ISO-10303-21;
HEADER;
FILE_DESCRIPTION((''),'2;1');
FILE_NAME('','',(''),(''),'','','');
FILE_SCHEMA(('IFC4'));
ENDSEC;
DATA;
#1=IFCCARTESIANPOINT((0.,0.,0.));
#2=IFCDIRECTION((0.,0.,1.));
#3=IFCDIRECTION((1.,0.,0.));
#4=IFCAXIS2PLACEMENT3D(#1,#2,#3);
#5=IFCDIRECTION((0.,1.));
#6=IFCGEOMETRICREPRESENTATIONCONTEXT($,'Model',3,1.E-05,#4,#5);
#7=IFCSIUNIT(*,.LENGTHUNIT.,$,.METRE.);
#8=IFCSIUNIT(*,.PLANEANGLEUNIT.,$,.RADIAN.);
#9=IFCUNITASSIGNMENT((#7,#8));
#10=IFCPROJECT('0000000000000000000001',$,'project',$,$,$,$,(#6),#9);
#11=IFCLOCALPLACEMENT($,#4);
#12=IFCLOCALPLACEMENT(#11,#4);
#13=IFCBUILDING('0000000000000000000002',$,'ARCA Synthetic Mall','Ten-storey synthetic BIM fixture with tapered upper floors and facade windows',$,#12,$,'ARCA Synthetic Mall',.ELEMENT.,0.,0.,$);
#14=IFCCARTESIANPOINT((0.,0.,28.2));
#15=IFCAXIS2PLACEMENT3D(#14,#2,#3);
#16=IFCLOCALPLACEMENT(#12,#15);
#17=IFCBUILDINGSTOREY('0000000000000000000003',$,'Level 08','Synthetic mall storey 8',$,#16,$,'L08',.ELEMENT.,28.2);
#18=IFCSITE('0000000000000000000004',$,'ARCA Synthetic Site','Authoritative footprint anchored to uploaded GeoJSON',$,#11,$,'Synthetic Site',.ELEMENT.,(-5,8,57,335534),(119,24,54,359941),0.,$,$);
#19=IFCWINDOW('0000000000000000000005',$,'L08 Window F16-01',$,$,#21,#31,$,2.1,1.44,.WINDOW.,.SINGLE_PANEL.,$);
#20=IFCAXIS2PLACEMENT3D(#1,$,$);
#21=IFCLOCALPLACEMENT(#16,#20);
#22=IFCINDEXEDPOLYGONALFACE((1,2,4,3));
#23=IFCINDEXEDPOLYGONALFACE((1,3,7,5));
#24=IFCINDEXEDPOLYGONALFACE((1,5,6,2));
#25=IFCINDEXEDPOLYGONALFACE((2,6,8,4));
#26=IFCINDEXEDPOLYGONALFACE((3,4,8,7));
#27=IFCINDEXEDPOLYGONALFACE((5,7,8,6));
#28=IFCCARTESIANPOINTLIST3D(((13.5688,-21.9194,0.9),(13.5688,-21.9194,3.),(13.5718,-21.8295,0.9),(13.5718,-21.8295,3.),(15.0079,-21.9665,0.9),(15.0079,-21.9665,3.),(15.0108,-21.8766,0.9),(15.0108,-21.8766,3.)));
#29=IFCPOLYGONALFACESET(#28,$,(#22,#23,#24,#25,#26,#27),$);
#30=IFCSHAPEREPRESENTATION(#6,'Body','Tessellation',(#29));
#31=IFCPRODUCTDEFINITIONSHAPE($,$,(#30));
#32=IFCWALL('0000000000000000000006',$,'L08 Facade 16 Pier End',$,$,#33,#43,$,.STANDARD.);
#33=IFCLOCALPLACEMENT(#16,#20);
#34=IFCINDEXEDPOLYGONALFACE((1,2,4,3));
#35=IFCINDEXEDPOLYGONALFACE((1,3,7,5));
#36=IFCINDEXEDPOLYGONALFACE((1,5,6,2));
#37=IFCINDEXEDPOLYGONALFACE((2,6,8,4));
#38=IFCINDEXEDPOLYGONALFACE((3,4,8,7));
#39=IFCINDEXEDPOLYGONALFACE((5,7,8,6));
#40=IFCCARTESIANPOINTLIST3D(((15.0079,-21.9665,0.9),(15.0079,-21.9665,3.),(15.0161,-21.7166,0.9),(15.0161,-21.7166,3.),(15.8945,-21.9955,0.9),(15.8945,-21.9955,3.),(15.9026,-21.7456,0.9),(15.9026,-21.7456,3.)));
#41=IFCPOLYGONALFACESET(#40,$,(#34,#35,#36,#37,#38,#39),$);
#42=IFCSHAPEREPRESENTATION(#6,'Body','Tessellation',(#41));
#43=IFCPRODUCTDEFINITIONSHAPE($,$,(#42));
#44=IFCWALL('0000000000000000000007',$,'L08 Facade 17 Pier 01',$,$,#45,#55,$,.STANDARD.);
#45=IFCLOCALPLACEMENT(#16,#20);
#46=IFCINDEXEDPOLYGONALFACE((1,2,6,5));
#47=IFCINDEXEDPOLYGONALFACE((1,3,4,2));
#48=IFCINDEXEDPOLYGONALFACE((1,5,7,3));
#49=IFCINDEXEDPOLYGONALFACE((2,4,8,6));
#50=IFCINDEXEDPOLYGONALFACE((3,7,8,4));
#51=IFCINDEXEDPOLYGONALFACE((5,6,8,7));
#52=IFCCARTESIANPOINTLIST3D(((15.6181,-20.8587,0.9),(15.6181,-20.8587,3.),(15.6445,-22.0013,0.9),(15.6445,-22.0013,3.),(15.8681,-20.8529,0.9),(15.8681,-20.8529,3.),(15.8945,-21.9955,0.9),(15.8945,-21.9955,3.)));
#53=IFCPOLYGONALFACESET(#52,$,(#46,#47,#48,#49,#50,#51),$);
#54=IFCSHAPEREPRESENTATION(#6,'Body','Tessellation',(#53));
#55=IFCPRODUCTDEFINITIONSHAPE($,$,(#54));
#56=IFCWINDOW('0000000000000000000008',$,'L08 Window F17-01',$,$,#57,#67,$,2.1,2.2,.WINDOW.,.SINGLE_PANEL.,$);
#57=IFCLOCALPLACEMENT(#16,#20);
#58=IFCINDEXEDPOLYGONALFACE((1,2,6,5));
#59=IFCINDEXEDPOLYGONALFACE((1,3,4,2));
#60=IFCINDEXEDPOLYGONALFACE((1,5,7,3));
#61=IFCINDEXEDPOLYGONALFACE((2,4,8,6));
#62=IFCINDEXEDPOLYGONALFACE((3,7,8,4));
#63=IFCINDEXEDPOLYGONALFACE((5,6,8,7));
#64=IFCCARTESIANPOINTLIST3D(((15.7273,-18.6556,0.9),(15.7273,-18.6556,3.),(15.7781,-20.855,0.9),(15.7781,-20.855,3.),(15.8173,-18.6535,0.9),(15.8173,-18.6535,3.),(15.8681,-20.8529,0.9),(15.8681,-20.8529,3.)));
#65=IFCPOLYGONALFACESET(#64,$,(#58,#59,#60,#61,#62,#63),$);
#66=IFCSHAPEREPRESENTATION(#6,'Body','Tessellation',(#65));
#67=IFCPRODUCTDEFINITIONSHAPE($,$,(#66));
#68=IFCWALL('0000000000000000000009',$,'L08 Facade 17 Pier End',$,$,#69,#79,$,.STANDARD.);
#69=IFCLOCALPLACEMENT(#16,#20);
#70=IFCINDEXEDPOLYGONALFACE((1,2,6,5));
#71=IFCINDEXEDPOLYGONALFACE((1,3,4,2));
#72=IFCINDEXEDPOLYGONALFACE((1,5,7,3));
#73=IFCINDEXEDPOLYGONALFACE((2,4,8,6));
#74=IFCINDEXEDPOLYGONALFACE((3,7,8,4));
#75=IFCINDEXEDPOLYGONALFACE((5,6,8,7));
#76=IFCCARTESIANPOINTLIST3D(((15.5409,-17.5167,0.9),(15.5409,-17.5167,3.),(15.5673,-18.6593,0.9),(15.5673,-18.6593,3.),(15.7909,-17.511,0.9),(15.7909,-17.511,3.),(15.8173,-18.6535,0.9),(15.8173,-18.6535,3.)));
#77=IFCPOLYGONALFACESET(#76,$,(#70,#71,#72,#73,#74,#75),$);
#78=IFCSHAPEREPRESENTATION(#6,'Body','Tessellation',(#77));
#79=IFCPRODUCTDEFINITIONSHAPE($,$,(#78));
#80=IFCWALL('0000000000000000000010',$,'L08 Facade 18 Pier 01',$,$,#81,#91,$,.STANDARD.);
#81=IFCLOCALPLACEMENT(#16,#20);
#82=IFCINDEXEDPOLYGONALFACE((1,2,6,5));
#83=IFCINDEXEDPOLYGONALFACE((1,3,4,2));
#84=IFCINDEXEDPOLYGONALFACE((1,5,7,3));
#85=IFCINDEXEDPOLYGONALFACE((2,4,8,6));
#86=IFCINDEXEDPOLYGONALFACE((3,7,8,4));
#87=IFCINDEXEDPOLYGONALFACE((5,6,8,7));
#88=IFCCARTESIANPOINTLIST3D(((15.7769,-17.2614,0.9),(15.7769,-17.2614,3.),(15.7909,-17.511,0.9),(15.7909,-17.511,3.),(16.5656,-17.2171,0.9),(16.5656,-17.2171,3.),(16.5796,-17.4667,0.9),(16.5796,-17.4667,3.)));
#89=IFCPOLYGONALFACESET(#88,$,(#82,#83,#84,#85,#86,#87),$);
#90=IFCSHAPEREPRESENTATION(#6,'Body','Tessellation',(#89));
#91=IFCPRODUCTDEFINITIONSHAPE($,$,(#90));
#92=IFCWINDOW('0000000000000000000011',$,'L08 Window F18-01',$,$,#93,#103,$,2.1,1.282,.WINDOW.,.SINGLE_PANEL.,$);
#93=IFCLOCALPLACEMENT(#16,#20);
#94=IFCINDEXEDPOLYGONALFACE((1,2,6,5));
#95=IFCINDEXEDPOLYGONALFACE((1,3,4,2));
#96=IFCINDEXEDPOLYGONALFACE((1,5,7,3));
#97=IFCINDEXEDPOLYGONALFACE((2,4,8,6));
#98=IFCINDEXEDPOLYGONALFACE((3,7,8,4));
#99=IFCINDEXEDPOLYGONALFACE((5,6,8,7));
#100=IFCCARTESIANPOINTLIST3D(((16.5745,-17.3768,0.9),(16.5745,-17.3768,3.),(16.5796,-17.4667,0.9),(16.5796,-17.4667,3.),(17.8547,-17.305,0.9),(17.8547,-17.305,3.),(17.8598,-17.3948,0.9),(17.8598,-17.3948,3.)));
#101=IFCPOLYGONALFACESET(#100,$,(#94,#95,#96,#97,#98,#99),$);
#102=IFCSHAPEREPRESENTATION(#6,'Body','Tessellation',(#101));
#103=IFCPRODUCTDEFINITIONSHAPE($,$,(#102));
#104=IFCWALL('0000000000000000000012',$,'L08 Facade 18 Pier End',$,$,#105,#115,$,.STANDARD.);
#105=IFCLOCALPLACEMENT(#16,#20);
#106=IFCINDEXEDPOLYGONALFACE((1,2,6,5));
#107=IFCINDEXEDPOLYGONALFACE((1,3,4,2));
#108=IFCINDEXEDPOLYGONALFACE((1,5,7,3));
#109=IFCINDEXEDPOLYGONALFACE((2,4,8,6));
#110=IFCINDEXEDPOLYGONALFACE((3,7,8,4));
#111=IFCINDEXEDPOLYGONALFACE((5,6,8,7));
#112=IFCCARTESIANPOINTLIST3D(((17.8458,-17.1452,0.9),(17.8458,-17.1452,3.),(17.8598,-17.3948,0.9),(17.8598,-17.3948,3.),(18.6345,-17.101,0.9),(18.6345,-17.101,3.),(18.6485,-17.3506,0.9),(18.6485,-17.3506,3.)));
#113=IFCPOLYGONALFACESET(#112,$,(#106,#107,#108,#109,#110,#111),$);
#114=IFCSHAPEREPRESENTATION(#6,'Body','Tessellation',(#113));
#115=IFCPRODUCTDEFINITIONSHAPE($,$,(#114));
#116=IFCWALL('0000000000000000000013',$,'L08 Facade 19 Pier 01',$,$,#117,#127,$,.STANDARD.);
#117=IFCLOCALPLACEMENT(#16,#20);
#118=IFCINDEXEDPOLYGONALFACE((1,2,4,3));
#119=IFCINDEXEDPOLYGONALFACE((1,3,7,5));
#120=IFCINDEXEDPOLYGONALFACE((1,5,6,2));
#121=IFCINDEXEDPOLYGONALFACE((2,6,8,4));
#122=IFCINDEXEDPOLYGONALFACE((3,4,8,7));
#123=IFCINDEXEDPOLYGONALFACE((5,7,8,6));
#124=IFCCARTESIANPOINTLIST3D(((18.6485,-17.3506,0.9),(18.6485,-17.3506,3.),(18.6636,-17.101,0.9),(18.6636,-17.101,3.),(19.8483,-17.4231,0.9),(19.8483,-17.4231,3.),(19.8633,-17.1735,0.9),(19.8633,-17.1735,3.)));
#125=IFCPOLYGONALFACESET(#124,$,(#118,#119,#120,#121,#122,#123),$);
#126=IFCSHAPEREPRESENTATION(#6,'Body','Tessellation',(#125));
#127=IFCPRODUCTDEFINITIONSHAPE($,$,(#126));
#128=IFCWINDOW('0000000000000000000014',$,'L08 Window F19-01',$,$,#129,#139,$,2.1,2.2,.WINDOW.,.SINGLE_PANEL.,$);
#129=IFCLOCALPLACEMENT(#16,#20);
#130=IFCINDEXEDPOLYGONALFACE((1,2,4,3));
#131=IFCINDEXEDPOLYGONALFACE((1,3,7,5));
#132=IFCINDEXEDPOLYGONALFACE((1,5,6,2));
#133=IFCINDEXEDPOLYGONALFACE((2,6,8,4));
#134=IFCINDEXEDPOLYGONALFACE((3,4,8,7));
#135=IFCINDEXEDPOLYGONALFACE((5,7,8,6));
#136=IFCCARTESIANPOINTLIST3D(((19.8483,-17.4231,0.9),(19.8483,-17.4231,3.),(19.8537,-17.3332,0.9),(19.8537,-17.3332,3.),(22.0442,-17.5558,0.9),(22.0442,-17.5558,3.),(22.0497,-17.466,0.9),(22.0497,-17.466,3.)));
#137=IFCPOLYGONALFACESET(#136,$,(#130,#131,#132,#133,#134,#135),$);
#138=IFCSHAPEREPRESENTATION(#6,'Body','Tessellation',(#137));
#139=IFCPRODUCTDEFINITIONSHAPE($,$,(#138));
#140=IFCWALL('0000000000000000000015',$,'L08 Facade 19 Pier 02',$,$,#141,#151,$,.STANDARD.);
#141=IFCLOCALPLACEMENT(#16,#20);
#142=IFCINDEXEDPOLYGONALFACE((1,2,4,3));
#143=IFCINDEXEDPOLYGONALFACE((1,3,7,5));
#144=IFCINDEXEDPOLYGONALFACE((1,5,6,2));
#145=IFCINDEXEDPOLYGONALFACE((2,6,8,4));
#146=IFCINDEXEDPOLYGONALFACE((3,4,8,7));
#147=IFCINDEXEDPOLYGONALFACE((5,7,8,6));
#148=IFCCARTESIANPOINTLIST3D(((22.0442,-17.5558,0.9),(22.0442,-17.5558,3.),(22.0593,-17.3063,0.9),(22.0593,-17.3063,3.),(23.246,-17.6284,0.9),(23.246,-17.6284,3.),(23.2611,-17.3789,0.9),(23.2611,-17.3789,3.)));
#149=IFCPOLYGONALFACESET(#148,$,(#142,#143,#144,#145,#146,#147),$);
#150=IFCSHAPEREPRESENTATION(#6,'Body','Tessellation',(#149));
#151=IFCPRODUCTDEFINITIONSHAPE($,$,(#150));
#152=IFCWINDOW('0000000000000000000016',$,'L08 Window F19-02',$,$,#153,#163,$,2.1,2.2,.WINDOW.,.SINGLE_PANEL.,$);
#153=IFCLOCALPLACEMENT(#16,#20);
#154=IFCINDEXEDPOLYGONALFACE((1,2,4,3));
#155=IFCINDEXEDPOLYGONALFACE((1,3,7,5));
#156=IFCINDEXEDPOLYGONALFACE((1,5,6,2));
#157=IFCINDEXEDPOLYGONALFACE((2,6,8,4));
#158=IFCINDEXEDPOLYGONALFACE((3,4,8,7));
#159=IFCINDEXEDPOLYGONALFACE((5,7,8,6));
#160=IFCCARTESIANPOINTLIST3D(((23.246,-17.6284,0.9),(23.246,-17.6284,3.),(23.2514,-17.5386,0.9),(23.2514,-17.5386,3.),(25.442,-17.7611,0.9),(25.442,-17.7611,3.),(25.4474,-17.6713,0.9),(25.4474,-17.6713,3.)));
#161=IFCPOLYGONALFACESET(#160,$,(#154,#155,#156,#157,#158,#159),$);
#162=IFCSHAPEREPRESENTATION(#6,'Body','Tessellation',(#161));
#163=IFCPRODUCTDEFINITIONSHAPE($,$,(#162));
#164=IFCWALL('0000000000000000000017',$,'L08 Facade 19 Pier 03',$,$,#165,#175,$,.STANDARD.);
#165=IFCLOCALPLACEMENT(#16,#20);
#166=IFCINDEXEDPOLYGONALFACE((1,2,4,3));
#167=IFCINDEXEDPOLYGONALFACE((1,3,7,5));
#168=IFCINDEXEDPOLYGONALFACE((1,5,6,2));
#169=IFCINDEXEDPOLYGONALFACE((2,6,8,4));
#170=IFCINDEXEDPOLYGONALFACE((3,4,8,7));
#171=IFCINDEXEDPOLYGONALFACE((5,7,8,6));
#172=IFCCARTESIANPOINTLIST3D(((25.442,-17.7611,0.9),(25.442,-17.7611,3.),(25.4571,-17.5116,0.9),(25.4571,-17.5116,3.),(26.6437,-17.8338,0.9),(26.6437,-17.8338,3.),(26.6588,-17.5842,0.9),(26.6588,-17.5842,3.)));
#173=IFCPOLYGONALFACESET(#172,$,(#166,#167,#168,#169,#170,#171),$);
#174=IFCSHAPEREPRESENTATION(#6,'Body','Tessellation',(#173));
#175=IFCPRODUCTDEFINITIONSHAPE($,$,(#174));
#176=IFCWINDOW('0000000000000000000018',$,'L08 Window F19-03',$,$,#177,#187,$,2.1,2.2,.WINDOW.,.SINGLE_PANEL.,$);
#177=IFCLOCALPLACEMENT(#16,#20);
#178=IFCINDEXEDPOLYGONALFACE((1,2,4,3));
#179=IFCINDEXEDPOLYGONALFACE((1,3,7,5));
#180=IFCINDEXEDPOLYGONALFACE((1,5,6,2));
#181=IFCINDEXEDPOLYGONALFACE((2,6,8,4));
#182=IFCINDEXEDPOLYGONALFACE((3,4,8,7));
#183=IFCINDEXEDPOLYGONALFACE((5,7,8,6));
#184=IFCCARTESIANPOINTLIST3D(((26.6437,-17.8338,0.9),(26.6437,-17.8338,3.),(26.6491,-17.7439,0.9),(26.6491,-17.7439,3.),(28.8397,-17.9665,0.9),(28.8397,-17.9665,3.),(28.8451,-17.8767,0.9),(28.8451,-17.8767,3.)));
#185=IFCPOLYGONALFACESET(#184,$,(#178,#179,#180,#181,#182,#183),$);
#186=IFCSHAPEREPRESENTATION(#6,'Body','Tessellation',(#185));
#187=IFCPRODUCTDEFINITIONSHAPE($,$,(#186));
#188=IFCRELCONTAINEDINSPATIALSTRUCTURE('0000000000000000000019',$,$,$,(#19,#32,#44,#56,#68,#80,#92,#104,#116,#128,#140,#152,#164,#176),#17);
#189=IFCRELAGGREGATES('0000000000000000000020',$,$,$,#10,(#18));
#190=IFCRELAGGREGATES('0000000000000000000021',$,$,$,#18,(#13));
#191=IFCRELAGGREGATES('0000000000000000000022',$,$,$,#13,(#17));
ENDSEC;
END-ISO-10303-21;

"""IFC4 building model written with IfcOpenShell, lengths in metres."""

from ifc_helpers import new_model, si_unit, direction, frame, origin_with_axes, place, context, project, spatial, polyline, outline, extrude, element, save


model = new_model("IFC4")

# Units and contexts
model_context = context("Model", 3, precision=1e-05, world=origin_with_axes(), true_north=direction((0.0, 1.0)))
ifc_project = project(units=[si_unit("LENGTHUNIT", "METRE"), si_unit("PLANEANGLEUNIT", "RADIAN")], contexts=[model_context])

# Site, building, storey
site_placement = place(None, origin_with_axes())
site = spatial("IfcSite", under=ifc_project, at=site_placement, Name="ARCA Synthetic Site", Description="Authoritative footprint anchored to uploaded GeoJSON", LongName="Synthetic Site", CompositionType="ELEMENT", RefLatitude=(-5, 8, 57, 335534), RefLongitude=(119, 24, 54, 359941), RefElevation=0.0)
building_placement = place(site_placement, origin_with_axes())
building = spatial("IfcBuilding", under=site, at=building_placement, Name="ARCA Synthetic Mall", Description="Ten-storey synthetic BIM fixture with tapered upper floors and facade windows", LongName="ARCA Synthetic Mall", CompositionType="ELEMENT", ElevationOfRefHeight=0.0, ElevationOfTerrain=0.0)
storey_placement = place(building_placement, frame((0.0, 0.0, 28.2), z_axis=(0.0, 0.0, 1.0), x_axis=(1.0, 0.0, 0.0)))
storey = spatial("IfcBuildingStorey", under=building, at=storey_placement, Name="Level 08", Description="Synthetic mall storey 8", LongName="L08", CompositionType="ELEMENT", Elevation=28.2)

# Window
window_1_placement = place(storey_placement, frame((0.0, 0.0, 0.9), z_axis=(0.0, 0.0, 1.0), x_axis=(1.0, 0.0, 0.0)))
element("IfcWindow", 1, at=window_1_placement, inside=storey, Name="L08 Window F16-01", OverallHeight=2.1, OverallWidth=1.44, PartitioningType="SINGLE_PANEL", PredefinedType="WINDOW", context=model_context, shape_type="SweptSolid", body=[
    extrude(outline(polyline([(13.5688, -21.9194), (15.0079, -21.9665), (15.0108, -21.8766), (13.5718, -21.8295), (13.5688, -21.9194)])), origin_with_axes(), (0.0, 0.0, 1.0), 2.1),
])

# Walls
wall_1_placement = place(storey_placement, frame((0.0, 0.0, 0.9), z_axis=(0.0, 0.0, 1.0), x_axis=(1.0, 0.0, 0.0)))
element("IfcWall", 2, at=wall_1_placement, inside=storey, Name="L08 Facade 16 Pier End", PredefinedType="STANDARD", context=model_context, shape_type="SweptSolid", body=[
    extrude(outline(polyline([(15.0079, -21.9665), (15.8945, -21.9955), (15.9026, -21.7456), (15.0161, -21.7166), (15.0079, -21.9665)])), origin_with_axes(), (0.0, 0.0, 1.0), 2.1),
])
wall_2_placement = place(storey_placement, frame((0.0, 0.0, 0.9), z_axis=(0.0, 0.0, 1.0), x_axis=(1.0, 0.0, 0.0)))
element("IfcWall", 3, at=wall_2_placement, inside=storey, Name="L08 Facade 17 Pier 01", PredefinedType="STANDARD", context=model_context, shape_type="SweptSolid", body=[
    extrude(outline(polyline([(15.8945, -21.9955), (15.8681, -20.8529), (15.6181, -20.8587), (15.6445, -22.0013), (15.8945, -21.9955)])), origin_with_axes(), (0.0, 0.0, 1.0), 2.1),
])

# Window
window_2_placement = place(storey_placement, frame((0.0, 0.0, 0.9), z_axis=(0.0, 0.0, 1.0), x_axis=(1.0, 0.0, 0.0)))
element("IfcWindow", 4, at=window_2_placement, inside=storey, Name="L08 Window F17-01", OverallHeight=2.1, OverallWidth=2.2, PartitioningType="SINGLE_PANEL", PredefinedType="WINDOW", context=model_context, shape_type="SweptSolid", body=[
    extrude(outline(polyline([(15.8681, -20.8529), (15.8173, -18.6535), (15.7273, -18.6556), (15.7781, -20.855), (15.8681, -20.8529)])), origin_with_axes(), (0.0, 0.0, 1.0), 2.1),
])

# Walls
wall_3_placement = place(storey_placement, frame((0.0, 0.0, 0.9), z_axis=(0.0, 0.0, 1.0), x_axis=(1.0, 0.0, 0.0)))
element("IfcWall", 5, at=wall_3_placement, inside=storey, Name="L08 Facade 17 Pier End", PredefinedType="STANDARD", context=model_context, shape_type="SweptSolid", body=[
    extrude(outline(polyline([(15.8173, -18.6535), (15.7909, -17.511), (15.5409, -17.5167), (15.5673, -18.6593), (15.8173, -18.6535)])), origin_with_axes(), (0.0, 0.0, 1.0), 2.1),
])
wall_4_placement = place(storey_placement, frame((0.0, 0.0, 0.9), z_axis=(0.0, 0.0, 1.0), x_axis=(1.0, 0.0, 0.0)))
element("IfcWall", 6, at=wall_4_placement, inside=storey, Name="L08 Facade 18 Pier 01", PredefinedType="STANDARD", context=model_context, shape_type="SweptSolid", body=[
    extrude(outline(polyline([(15.7909, -17.511), (16.5796, -17.4667), (16.5656, -17.2171), (15.7769, -17.2614), (15.7909, -17.511)])), origin_with_axes(), (0.0, 0.0, 1.0), 2.1),
])

# Window
window_3_placement = place(storey_placement, frame((0.0, 0.0, 0.9), z_axis=(0.0, 0.0, 1.0), x_axis=(1.0, 0.0, 0.0)))
element("IfcWindow", 7, at=window_3_placement, inside=storey, Name="L08 Window F18-01", OverallHeight=2.1, OverallWidth=1.282, PartitioningType="SINGLE_PANEL", PredefinedType="WINDOW", context=model_context, shape_type="SweptSolid", body=[
    extrude(outline(polyline([(16.5796, -17.4667), (17.8598, -17.3948), (17.8547, -17.305), (16.5745, -17.3768), (16.5796, -17.4667)])), origin_with_axes(), (0.0, 0.0, 1.0), 2.1),
])

# Walls
wall_5_placement = place(storey_placement, frame((0.0, 0.0, 0.9), z_axis=(0.0, 0.0, 1.0), x_axis=(1.0, 0.0, 0.0)))
element("IfcWall", 8, at=wall_5_placement, inside=storey, Name="L08 Facade 18 Pier End", PredefinedType="STANDARD", context=model_context, shape_type="SweptSolid", body=[
    extrude(outline(polyline([(17.8598, -17.3948), (18.6485, -17.3506), (18.6345, -17.101), (17.8458, -17.1452), (17.8598, -17.3948)])), origin_with_axes(), (0.0, 0.0, 1.0), 2.1),
])
wall_6_placement = place(storey_placement, frame((0.0, 0.0, 0.9), z_axis=(0.0, 0.0, 1.0), x_axis=(1.0, 0.0, 0.0)))
element("IfcWall", 9, at=wall_6_placement, inside=storey, Name="L08 Facade 19 Pier 01", PredefinedType="STANDARD", context=model_context, shape_type="SweptSolid", body=[
    extrude(outline(polyline([(18.6485, -17.3506), (19.8483, -17.4231), (19.8633, -17.1735), (18.6636, -17.101), (18.6485, -17.3506)])), origin_with_axes(), (0.0, 0.0, 1.0), 2.1),
])

# Window
window_4_placement = place(storey_placement, frame((0.0, 0.0, 0.9), z_axis=(0.0, 0.0, 1.0), x_axis=(1.0, 0.0, 0.0)))
element("IfcWindow", 10, at=window_4_placement, inside=storey, Name="L08 Window F19-01", OverallHeight=2.1, OverallWidth=2.2, PartitioningType="SINGLE_PANEL", PredefinedType="WINDOW", context=model_context, shape_type="SweptSolid", body=[
    extrude(outline(polyline([(19.8483, -17.4231), (22.0442, -17.5558), (22.0497, -17.466), (19.8537, -17.3332), (19.8483, -17.4231)])), origin_with_axes(), (0.0, 0.0, 1.0), 2.1),
])

# Wall
wall_7_placement = place(storey_placement, frame((0.0, 0.0, 0.9), z_axis=(0.0, 0.0, 1.0), x_axis=(1.0, 0.0, 0.0)))
element("IfcWall", 11, at=wall_7_placement, inside=storey, Name="L08 Facade 19 Pier 02", PredefinedType="STANDARD", context=model_context, shape_type="SweptSolid", body=[
    extrude(outline(polyline([(22.0442, -17.5558), (23.246, -17.6284), (23.2611, -17.3789), (22.0593, -17.3063), (22.0442, -17.5558)])), origin_with_axes(), (0.0, 0.0, 1.0), 2.1),
])

# Window
window_5_placement = place(storey_placement, frame((0.0, 0.0, 0.9), z_axis=(0.0, 0.0, 1.0), x_axis=(1.0, 0.0, 0.0)))
element("IfcWindow", 12, at=window_5_placement, inside=storey, Name="L08 Window F19-02", OverallHeight=2.1, OverallWidth=2.2, PartitioningType="SINGLE_PANEL", PredefinedType="WINDOW", context=model_context, shape_type="SweptSolid", body=[
    extrude(outline(polyline([(23.246, -17.6284), (25.442, -17.7611), (25.4474, -17.6713), (23.2514, -17.5386), (23.246, -17.6284)])), origin_with_axes(), (0.0, 0.0, 1.0), 2.1),
])

# Wall
wall_8_placement = place(storey_placement, frame((0.0, 0.0, 0.9), z_axis=(0.0, 0.0, 1.0), x_axis=(1.0, 0.0, 0.0)))
element("IfcWall", 13, at=wall_8_placement, inside=storey, Name="L08 Facade 19 Pier 03", PredefinedType="STANDARD", context=model_context, shape_type="SweptSolid", body=[
    extrude(outline(polyline([(25.442, -17.7611), (26.6437, -17.8338), (26.6588, -17.5842), (25.4571, -17.5116), (25.442, -17.7611)])), origin_with_axes(), (0.0, 0.0, 1.0), 2.1),
])

# Window
window_6_placement = place(storey_placement, frame((0.0, 0.0, 0.9), z_axis=(0.0, 0.0, 1.0), x_axis=(1.0, 0.0, 0.0)))
element("IfcWindow", 14, at=window_6_placement, inside=storey, Name="L08 Window F19-03", OverallHeight=2.1, OverallWidth=2.2, PartitioningType="SINGLE_PANEL", PredefinedType="WINDOW", context=model_context, shape_type="SweptSolid", body=[
    extrude(outline(polyline([(26.6437, -17.8338), (28.8397, -17.9665), (28.8451, -17.8767), (26.6491, -17.7439), (26.6437, -17.8338)])), origin_with_axes(), (0.0, 0.0, 1.0), 2.1),
])

save(model, "model.ifc")
